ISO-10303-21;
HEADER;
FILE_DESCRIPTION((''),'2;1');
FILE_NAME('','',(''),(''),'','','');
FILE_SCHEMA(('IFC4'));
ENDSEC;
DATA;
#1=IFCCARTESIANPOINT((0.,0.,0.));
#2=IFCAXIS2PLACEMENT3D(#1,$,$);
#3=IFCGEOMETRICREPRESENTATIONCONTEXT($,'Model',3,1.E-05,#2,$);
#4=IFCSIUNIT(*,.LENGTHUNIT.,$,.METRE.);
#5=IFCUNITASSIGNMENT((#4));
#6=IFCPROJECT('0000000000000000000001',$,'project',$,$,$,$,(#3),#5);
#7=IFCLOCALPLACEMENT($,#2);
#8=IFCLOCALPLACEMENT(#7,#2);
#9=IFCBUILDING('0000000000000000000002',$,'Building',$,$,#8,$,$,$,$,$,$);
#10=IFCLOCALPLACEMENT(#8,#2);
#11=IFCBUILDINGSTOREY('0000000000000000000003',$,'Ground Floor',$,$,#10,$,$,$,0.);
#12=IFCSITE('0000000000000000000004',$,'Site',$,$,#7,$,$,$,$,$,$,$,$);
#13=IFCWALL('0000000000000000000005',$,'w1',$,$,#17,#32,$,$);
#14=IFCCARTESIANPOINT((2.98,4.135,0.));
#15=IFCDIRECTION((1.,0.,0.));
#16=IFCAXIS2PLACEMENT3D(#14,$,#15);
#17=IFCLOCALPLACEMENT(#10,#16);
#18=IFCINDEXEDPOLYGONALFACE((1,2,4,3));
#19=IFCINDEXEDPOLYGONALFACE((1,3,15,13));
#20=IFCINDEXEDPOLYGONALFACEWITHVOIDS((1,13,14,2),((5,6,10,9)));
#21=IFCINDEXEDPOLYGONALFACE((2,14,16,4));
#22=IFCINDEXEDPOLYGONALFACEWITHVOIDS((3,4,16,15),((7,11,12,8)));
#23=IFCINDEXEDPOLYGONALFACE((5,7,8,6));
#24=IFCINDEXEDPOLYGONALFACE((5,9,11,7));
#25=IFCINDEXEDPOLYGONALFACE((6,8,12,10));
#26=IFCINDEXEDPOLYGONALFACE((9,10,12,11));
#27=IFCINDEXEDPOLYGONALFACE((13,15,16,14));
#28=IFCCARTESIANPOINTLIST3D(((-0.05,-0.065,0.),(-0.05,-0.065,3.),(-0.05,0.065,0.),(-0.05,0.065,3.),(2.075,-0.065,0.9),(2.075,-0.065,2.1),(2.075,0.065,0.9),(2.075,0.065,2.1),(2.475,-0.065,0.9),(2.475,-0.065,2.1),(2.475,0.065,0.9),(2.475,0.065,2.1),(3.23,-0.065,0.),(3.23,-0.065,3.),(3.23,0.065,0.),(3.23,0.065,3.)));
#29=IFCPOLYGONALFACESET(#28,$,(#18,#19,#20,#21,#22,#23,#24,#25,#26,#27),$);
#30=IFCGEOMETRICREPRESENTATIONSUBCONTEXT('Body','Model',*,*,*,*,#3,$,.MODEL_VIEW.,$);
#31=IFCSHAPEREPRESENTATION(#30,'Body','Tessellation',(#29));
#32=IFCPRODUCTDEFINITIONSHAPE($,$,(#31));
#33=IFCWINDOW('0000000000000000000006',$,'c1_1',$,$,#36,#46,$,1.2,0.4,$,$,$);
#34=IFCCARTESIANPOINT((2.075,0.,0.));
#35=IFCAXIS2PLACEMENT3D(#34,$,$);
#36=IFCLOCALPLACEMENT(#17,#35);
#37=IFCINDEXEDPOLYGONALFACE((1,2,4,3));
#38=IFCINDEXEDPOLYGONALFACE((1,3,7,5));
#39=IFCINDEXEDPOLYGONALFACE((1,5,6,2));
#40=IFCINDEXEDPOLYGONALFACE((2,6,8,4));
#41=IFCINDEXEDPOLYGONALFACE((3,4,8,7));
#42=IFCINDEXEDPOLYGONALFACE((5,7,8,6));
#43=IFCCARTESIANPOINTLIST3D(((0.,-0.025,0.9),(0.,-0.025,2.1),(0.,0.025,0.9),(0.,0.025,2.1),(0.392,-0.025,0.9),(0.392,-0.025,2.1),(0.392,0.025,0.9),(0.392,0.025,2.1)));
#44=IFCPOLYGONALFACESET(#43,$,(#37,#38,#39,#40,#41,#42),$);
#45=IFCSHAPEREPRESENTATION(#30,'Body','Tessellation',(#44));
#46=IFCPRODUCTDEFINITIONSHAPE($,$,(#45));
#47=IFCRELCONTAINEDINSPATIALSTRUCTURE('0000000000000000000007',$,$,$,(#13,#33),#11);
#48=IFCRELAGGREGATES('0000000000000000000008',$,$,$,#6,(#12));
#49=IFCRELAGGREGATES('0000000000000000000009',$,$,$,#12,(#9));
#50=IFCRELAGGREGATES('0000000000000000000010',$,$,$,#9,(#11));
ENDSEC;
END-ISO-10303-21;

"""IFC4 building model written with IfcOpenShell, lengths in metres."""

from ifc_helpers import new_model, si_unit, frame, origin, place, context, subcontext, project, spatial, polyline, outline, extrude, element, fill, save


model = new_model("IFC4")

# Units and contexts
model_context = context("Model", 3, precision=1e-05, world=origin())
body_context = subcontext(model_context, "Body", "Model", "MODEL_VIEW")
ifc_project = project(units=[si_unit("LENGTHUNIT", "METRE")], contexts=[model_context])

# Site, building, storey
site_placement = place(None, origin())
site = spatial("IfcSite", under=ifc_project, at=site_placement, Name="Site")
building_placement = place(site_placement, origin())
building = spatial("IfcBuilding", under=site, at=building_placement, Name="Building")
storey_placement = place(building_placement, origin())
storey = spatial("IfcBuildingStorey", under=building, at=storey_placement, Name="Ground Floor", Elevation=0.0)

# Wall, opening, window
wall_1_placement = place(storey_placement, frame((2.98, 4.135, 0.0), x_axis=(1.0, 0.0, 0.0)))
wall_1 = element("IfcWall", 1, at=wall_1_placement, inside=storey, Name="w1", context=body_context, shape_type="SweptSolid", body=[
    extrude(outline(polyline([(-0.05, -0.065), (3.23, -0.065), (3.23, 0.065), (-0.05, 0.065), (-0.05, -0.065)])), origin(), (0.0, 0.0, 1.0), 3.0),
])
opening_1_placement = place(wall_1_placement, frame((2.075, 0.0, 0.0)))
opening_1 = element("IfcOpeningElement", 2, at=opening_1_placement, cuts=wall_1, context=body_context, shape_type="SweptSolid", body=[
    extrude(outline(polyline([(0.0, -0.0682), (0.4, -0.0682), (0.4, 0.0682), (0.0, 0.0682), (0.0, -0.0682)])), frame((0.0, 0.0, 0.9)), (0.0, 0.0, 1.0), 1.2),
])
window_placement = place(wall_1_placement, frame((2.075, 0.0, 0.0)))
window = element("IfcWindow", 3, at=window_placement, inside=storey, Name="c1_1", OverallHeight=1.2, OverallWidth=0.4, context=body_context, shape_type="SweptSolid", body=[
    extrude(outline(polyline([(0.0, -0.025), (0.392, -0.025), (0.392, 0.025), (0.0, 0.025), (0.0, -0.025)])), frame((0.0, 0.0, 0.9)), (0.0, 0.0, 1.0), 1.2),
])
fill(opening_1, window)

save(model, "model.ifc")
